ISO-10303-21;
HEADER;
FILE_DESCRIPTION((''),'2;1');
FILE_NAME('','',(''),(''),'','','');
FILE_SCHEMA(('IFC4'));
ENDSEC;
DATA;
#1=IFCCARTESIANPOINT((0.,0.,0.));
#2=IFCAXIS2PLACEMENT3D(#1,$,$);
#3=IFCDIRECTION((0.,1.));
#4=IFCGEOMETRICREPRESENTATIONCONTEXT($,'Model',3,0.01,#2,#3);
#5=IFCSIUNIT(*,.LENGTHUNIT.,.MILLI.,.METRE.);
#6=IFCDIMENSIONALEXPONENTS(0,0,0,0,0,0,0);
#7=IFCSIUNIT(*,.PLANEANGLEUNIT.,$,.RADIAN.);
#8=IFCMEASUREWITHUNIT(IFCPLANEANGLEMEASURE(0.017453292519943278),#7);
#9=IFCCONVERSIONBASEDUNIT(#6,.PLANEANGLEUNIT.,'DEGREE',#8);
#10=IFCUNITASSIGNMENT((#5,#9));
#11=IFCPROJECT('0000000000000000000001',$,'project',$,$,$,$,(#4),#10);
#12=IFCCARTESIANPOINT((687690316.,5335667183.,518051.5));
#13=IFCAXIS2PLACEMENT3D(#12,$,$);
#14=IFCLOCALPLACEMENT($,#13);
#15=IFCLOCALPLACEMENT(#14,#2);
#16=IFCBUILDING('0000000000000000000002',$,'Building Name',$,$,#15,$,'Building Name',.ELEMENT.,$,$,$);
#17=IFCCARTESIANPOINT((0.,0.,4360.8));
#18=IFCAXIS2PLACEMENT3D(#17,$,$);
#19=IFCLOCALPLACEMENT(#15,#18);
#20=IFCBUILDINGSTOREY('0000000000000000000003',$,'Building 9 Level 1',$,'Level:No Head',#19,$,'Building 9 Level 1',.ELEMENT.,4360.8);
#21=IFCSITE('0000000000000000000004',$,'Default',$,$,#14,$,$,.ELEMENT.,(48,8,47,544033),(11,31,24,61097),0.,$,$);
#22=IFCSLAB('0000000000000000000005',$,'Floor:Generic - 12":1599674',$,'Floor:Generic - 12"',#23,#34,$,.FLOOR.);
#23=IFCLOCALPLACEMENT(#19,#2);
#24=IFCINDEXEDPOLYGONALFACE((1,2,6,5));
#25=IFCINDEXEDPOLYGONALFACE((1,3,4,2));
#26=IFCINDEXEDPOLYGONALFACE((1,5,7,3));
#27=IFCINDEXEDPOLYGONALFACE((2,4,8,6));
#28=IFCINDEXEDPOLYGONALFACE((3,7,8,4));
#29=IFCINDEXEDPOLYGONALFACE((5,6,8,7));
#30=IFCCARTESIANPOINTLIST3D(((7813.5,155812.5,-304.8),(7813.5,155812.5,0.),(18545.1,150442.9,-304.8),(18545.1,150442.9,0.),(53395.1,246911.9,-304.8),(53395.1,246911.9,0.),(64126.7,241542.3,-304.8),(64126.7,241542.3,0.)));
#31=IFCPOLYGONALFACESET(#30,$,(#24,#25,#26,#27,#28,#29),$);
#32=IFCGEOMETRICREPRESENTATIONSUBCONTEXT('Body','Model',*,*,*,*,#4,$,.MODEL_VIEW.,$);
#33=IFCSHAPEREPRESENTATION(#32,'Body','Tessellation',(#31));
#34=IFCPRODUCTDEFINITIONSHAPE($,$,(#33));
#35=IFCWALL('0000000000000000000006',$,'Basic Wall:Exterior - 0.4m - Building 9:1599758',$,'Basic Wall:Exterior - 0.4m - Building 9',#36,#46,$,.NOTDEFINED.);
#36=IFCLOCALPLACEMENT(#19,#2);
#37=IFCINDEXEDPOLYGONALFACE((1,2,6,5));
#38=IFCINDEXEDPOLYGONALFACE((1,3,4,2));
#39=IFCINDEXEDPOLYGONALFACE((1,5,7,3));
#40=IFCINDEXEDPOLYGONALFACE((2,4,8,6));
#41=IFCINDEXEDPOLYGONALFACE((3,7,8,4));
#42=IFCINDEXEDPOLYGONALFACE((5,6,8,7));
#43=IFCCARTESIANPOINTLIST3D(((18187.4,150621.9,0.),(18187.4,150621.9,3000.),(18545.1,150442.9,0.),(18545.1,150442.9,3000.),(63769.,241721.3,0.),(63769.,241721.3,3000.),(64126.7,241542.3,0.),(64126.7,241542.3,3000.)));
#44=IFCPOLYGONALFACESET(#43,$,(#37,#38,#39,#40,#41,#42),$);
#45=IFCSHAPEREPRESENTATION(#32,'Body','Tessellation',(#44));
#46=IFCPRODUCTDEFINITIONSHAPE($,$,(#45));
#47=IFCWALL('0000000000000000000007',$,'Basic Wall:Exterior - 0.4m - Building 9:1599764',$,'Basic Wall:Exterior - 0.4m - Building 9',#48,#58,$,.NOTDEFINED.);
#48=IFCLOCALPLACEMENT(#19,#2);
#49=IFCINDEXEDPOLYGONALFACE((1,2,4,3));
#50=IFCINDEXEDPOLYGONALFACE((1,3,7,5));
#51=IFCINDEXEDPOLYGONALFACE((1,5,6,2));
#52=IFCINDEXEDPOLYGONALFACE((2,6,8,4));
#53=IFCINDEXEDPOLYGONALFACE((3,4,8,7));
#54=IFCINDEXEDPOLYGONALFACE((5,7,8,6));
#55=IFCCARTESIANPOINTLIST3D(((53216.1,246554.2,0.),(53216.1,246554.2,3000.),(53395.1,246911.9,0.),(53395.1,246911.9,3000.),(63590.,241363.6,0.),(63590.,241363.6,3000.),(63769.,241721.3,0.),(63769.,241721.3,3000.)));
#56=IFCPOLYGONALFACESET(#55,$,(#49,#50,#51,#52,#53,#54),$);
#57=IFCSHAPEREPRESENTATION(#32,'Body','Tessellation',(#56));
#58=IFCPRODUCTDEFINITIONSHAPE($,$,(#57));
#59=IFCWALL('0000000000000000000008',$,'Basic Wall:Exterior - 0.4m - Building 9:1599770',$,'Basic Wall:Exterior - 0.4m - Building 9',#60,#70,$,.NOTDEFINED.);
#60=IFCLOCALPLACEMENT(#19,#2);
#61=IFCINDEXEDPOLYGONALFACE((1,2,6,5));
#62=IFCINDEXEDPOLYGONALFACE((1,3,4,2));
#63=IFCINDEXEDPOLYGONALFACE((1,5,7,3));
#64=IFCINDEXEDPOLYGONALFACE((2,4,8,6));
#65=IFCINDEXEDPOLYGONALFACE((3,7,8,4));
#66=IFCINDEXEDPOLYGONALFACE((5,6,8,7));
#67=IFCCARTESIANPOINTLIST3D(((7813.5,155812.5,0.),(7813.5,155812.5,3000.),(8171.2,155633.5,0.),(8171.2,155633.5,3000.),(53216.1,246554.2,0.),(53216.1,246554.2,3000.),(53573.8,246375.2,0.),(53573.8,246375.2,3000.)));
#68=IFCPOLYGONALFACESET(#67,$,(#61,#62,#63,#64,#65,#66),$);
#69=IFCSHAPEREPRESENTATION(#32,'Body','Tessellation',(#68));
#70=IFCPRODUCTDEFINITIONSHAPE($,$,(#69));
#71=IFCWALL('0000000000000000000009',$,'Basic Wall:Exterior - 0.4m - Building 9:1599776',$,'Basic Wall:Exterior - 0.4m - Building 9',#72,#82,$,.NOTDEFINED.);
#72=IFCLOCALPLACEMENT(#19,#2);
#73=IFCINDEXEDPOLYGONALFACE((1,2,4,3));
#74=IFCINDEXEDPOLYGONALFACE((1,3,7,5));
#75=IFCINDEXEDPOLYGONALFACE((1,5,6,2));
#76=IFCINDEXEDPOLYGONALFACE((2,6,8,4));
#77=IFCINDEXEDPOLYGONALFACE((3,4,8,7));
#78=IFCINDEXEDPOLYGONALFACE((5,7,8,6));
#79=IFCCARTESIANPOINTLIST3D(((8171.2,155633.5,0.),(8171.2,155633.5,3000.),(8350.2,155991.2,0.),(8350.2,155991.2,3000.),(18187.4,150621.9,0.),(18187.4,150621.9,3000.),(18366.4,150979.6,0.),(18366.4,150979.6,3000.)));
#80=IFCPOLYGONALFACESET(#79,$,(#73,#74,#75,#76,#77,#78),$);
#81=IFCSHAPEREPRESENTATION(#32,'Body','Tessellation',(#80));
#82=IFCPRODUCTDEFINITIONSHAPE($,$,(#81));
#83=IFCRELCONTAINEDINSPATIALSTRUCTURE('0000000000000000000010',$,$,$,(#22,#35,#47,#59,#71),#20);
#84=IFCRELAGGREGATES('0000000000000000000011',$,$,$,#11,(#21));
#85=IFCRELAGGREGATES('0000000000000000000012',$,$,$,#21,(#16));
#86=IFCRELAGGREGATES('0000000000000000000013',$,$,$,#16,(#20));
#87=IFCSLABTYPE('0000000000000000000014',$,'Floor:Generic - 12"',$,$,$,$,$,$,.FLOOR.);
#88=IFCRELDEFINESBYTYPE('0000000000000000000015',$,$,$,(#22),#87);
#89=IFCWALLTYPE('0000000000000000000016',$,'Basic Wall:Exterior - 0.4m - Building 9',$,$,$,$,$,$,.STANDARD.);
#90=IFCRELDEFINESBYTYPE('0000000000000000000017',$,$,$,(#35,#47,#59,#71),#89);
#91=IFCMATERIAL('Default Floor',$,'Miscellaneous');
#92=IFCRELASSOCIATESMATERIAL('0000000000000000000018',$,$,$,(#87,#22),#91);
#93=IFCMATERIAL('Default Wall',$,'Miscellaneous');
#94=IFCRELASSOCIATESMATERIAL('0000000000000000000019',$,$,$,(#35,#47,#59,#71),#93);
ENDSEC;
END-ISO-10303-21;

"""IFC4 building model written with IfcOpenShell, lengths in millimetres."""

from ifc_helpers import new_model, entity, si_unit, converted_unit, direction, frame, origin, place, context, subcontext, project, spatial, indexed_curve, outline, extrude, material, type_object, element, save


model = new_model("IFC4")

# Units and contexts
model_context = context("Model", 3, precision=0.01, world=origin(), true_north=direction((0.0, 1.0)))
body_context = subcontext(model_context, "Body", "Model", "MODEL_VIEW")
ifc_project = project(units=[si_unit("LENGTHUNIT", "METRE", prefix="MILLI"), converted_unit("PLANEANGLEUNIT", "DEGREE", entity("IfcPlaneAngleMeasure", 0.017453292519943278), si_unit("PLANEANGLEUNIT", "RADIAN"), dimensions=[0, 0, 0, 0, 0, 0, 0])], contexts=[model_context])

# Site, building, storey
site_placement = place(None, frame((687690316.0, 5335667183.0, 518051.5)))
site = spatial("IfcSite", under=ifc_project, at=site_placement, Name="Default", CompositionType="ELEMENT", RefLatitude=(48, 8, 47, 544033), RefLongitude=(11, 31, 24, 61097), RefElevation=0.0)
building_placement = place(site_placement, origin())
building = spatial("IfcBuilding", under=site, at=building_placement, Name="Building Name", LongName="Building Name", CompositionType="ELEMENT")
storey_placement = place(building_placement, frame((0.0, 0.0, 4360.8)))
storey = spatial("IfcBuildingStorey", under=building, at=storey_placement, Name="Building 9 Level 1", ObjectType="Level:No Head", LongName="Building 9 Level 1", CompositionType="ELEMENT", Elevation=4360.8)

# Slab
ifc_material_1 = material(Name="Default Floor", Category="Miscellaneous")
slab_type = type_object("IfcSlabType", Name="Floor:Generic - 12\"", PredefinedType="FLOOR", material=ifc_material_1)
slab_placement = place(storey_placement, origin())
element("IfcSlab", 1, at=slab_placement, inside=storey, type_object=slab_type, material=ifc_material_1, Name="Floor:Generic - 12\":1599674", ObjectType="Floor:Generic - 12\"", PredefinedType="FLOOR", context=body_context, shape_type="SweptSolid", body=[
    extrude(outline(indexed_curve([(-50933.2, -6000.0), (50933.2, -6000.0), (50933.2, 6000.0), (-50933.2, 6000.0), (-50933.2, -6000.0)], self_intersect=False)), frame((35970.1, 198677.4, 0.0), z_axis=(0.0, 0.0, -1.0), x_axis=(-0.447464, -0.894302, 0.0)), (0.0, 0.0, 1.0), 304.8),
])

# Walls
ifc_material_2 = material(Name="Default Wall", Category="Miscellaneous")
wall_type = type_object("IfcWallType", Name="Basic Wall:Exterior - 0.4m - Building 9", PredefinedType="STANDARD")
wall_1_placement = place(storey_placement, frame((18366.3, 150532.4, 0.0), z_axis=(0.0, 0.0, 1.0), x_axis=(0.447464, 0.894302, 0.0)))
element("IfcWall", 2, at=wall_1_placement, inside=storey, type_object=wall_type, material=ifc_material_2, Name="Basic Wall:Exterior - 0.4m - Building 9:1599758", ObjectType="Basic Wall:Exterior - 0.4m - Building 9", PredefinedType="NOTDEFINED", context=body_context, shape_type="SweptSolid", body=[
    extrude(outline(indexed_curve([(101866.5, 200.0), (0.0, 200.0), (0.0, -200.0), (101866.5, -200.0), (101866.5, 200.0)], self_intersect=False)), origin(), (0.0, 0.0, 1.0), 3000.0),
])
wall_2_placement = place(storey_placement, frame((63679.5, 241542.5, 0.0), z_axis=(0.0, 0.0, 1.0), x_axis=(-0.894302, 0.447464, 0.0)))
element("IfcWall", 3, at=wall_2_placement, inside=storey, type_object=wall_type, material=ifc_material_2, Name="Basic Wall:Exterior - 0.4m - Building 9:1599764", ObjectType="Basic Wall:Exterior - 0.4m - Building 9", PredefinedType="NOTDEFINED", context=body_context, shape_type="SweptSolid", body=[
    extrude(outline(indexed_curve([(11600.0, 200.0), (0.0, 200.0), (0.0, -200.0), (11600.0, -200.0), (11600.0, 200.0)], self_intersect=False)), origin(), (0.0, 0.0, 1.0), 3000.0),
])
wall_3_placement = place(storey_placement, frame((53395.0, 246464.7, 0.0), z_axis=(0.0, 0.0, 1.0), x_axis=(-0.447464, -0.894302, 0.0)))
element("IfcWall", 4, at=wall_3_placement, inside=storey, type_object=wall_type, material=ifc_material_2, Name="Basic Wall:Exterior - 0.4m - Building 9:1599770", ObjectType="Basic Wall:Exterior - 0.4m - Building 9", PredefinedType="NOTDEFINED", context=body_context, shape_type="SweptSolid", body=[
    extrude(outline(indexed_curve([(101466.5, 200.0), (0.0, 200.0), (0.0, -200.0), (101466.5, -200.0), (101466.5, 200.0)], self_intersect=False)), origin(), (0.0, 0.0, 1.0), 3000.0),
])
wall_4_placement = place(storey_placement, frame((8260.7, 155812.4, 0.0), z_axis=(0.0, 0.0, 1.0), x_axis=(0.894302, -0.447464, 0.0)))
element("IfcWall", 5, at=wall_4_placement, inside=storey, type_object=wall_type, material=ifc_material_2, Name="Basic Wall:Exterior - 0.4m - Building 9:1599776", ObjectType="Basic Wall:Exterior - 0.4m - Building 9", PredefinedType="NOTDEFINED", context=body_context, shape_type="SweptSolid", body=[
    extrude(outline(indexed_curve([(11200.0, 200.0), (0.0, 200.0), (0.0, -200.0), (11200.0, -200.0), (11200.0, 200.0)], self_intersect=False)), origin(), (0.0, 0.0, 1.0), 3000.0),
])

save(model, "model.ifc")
